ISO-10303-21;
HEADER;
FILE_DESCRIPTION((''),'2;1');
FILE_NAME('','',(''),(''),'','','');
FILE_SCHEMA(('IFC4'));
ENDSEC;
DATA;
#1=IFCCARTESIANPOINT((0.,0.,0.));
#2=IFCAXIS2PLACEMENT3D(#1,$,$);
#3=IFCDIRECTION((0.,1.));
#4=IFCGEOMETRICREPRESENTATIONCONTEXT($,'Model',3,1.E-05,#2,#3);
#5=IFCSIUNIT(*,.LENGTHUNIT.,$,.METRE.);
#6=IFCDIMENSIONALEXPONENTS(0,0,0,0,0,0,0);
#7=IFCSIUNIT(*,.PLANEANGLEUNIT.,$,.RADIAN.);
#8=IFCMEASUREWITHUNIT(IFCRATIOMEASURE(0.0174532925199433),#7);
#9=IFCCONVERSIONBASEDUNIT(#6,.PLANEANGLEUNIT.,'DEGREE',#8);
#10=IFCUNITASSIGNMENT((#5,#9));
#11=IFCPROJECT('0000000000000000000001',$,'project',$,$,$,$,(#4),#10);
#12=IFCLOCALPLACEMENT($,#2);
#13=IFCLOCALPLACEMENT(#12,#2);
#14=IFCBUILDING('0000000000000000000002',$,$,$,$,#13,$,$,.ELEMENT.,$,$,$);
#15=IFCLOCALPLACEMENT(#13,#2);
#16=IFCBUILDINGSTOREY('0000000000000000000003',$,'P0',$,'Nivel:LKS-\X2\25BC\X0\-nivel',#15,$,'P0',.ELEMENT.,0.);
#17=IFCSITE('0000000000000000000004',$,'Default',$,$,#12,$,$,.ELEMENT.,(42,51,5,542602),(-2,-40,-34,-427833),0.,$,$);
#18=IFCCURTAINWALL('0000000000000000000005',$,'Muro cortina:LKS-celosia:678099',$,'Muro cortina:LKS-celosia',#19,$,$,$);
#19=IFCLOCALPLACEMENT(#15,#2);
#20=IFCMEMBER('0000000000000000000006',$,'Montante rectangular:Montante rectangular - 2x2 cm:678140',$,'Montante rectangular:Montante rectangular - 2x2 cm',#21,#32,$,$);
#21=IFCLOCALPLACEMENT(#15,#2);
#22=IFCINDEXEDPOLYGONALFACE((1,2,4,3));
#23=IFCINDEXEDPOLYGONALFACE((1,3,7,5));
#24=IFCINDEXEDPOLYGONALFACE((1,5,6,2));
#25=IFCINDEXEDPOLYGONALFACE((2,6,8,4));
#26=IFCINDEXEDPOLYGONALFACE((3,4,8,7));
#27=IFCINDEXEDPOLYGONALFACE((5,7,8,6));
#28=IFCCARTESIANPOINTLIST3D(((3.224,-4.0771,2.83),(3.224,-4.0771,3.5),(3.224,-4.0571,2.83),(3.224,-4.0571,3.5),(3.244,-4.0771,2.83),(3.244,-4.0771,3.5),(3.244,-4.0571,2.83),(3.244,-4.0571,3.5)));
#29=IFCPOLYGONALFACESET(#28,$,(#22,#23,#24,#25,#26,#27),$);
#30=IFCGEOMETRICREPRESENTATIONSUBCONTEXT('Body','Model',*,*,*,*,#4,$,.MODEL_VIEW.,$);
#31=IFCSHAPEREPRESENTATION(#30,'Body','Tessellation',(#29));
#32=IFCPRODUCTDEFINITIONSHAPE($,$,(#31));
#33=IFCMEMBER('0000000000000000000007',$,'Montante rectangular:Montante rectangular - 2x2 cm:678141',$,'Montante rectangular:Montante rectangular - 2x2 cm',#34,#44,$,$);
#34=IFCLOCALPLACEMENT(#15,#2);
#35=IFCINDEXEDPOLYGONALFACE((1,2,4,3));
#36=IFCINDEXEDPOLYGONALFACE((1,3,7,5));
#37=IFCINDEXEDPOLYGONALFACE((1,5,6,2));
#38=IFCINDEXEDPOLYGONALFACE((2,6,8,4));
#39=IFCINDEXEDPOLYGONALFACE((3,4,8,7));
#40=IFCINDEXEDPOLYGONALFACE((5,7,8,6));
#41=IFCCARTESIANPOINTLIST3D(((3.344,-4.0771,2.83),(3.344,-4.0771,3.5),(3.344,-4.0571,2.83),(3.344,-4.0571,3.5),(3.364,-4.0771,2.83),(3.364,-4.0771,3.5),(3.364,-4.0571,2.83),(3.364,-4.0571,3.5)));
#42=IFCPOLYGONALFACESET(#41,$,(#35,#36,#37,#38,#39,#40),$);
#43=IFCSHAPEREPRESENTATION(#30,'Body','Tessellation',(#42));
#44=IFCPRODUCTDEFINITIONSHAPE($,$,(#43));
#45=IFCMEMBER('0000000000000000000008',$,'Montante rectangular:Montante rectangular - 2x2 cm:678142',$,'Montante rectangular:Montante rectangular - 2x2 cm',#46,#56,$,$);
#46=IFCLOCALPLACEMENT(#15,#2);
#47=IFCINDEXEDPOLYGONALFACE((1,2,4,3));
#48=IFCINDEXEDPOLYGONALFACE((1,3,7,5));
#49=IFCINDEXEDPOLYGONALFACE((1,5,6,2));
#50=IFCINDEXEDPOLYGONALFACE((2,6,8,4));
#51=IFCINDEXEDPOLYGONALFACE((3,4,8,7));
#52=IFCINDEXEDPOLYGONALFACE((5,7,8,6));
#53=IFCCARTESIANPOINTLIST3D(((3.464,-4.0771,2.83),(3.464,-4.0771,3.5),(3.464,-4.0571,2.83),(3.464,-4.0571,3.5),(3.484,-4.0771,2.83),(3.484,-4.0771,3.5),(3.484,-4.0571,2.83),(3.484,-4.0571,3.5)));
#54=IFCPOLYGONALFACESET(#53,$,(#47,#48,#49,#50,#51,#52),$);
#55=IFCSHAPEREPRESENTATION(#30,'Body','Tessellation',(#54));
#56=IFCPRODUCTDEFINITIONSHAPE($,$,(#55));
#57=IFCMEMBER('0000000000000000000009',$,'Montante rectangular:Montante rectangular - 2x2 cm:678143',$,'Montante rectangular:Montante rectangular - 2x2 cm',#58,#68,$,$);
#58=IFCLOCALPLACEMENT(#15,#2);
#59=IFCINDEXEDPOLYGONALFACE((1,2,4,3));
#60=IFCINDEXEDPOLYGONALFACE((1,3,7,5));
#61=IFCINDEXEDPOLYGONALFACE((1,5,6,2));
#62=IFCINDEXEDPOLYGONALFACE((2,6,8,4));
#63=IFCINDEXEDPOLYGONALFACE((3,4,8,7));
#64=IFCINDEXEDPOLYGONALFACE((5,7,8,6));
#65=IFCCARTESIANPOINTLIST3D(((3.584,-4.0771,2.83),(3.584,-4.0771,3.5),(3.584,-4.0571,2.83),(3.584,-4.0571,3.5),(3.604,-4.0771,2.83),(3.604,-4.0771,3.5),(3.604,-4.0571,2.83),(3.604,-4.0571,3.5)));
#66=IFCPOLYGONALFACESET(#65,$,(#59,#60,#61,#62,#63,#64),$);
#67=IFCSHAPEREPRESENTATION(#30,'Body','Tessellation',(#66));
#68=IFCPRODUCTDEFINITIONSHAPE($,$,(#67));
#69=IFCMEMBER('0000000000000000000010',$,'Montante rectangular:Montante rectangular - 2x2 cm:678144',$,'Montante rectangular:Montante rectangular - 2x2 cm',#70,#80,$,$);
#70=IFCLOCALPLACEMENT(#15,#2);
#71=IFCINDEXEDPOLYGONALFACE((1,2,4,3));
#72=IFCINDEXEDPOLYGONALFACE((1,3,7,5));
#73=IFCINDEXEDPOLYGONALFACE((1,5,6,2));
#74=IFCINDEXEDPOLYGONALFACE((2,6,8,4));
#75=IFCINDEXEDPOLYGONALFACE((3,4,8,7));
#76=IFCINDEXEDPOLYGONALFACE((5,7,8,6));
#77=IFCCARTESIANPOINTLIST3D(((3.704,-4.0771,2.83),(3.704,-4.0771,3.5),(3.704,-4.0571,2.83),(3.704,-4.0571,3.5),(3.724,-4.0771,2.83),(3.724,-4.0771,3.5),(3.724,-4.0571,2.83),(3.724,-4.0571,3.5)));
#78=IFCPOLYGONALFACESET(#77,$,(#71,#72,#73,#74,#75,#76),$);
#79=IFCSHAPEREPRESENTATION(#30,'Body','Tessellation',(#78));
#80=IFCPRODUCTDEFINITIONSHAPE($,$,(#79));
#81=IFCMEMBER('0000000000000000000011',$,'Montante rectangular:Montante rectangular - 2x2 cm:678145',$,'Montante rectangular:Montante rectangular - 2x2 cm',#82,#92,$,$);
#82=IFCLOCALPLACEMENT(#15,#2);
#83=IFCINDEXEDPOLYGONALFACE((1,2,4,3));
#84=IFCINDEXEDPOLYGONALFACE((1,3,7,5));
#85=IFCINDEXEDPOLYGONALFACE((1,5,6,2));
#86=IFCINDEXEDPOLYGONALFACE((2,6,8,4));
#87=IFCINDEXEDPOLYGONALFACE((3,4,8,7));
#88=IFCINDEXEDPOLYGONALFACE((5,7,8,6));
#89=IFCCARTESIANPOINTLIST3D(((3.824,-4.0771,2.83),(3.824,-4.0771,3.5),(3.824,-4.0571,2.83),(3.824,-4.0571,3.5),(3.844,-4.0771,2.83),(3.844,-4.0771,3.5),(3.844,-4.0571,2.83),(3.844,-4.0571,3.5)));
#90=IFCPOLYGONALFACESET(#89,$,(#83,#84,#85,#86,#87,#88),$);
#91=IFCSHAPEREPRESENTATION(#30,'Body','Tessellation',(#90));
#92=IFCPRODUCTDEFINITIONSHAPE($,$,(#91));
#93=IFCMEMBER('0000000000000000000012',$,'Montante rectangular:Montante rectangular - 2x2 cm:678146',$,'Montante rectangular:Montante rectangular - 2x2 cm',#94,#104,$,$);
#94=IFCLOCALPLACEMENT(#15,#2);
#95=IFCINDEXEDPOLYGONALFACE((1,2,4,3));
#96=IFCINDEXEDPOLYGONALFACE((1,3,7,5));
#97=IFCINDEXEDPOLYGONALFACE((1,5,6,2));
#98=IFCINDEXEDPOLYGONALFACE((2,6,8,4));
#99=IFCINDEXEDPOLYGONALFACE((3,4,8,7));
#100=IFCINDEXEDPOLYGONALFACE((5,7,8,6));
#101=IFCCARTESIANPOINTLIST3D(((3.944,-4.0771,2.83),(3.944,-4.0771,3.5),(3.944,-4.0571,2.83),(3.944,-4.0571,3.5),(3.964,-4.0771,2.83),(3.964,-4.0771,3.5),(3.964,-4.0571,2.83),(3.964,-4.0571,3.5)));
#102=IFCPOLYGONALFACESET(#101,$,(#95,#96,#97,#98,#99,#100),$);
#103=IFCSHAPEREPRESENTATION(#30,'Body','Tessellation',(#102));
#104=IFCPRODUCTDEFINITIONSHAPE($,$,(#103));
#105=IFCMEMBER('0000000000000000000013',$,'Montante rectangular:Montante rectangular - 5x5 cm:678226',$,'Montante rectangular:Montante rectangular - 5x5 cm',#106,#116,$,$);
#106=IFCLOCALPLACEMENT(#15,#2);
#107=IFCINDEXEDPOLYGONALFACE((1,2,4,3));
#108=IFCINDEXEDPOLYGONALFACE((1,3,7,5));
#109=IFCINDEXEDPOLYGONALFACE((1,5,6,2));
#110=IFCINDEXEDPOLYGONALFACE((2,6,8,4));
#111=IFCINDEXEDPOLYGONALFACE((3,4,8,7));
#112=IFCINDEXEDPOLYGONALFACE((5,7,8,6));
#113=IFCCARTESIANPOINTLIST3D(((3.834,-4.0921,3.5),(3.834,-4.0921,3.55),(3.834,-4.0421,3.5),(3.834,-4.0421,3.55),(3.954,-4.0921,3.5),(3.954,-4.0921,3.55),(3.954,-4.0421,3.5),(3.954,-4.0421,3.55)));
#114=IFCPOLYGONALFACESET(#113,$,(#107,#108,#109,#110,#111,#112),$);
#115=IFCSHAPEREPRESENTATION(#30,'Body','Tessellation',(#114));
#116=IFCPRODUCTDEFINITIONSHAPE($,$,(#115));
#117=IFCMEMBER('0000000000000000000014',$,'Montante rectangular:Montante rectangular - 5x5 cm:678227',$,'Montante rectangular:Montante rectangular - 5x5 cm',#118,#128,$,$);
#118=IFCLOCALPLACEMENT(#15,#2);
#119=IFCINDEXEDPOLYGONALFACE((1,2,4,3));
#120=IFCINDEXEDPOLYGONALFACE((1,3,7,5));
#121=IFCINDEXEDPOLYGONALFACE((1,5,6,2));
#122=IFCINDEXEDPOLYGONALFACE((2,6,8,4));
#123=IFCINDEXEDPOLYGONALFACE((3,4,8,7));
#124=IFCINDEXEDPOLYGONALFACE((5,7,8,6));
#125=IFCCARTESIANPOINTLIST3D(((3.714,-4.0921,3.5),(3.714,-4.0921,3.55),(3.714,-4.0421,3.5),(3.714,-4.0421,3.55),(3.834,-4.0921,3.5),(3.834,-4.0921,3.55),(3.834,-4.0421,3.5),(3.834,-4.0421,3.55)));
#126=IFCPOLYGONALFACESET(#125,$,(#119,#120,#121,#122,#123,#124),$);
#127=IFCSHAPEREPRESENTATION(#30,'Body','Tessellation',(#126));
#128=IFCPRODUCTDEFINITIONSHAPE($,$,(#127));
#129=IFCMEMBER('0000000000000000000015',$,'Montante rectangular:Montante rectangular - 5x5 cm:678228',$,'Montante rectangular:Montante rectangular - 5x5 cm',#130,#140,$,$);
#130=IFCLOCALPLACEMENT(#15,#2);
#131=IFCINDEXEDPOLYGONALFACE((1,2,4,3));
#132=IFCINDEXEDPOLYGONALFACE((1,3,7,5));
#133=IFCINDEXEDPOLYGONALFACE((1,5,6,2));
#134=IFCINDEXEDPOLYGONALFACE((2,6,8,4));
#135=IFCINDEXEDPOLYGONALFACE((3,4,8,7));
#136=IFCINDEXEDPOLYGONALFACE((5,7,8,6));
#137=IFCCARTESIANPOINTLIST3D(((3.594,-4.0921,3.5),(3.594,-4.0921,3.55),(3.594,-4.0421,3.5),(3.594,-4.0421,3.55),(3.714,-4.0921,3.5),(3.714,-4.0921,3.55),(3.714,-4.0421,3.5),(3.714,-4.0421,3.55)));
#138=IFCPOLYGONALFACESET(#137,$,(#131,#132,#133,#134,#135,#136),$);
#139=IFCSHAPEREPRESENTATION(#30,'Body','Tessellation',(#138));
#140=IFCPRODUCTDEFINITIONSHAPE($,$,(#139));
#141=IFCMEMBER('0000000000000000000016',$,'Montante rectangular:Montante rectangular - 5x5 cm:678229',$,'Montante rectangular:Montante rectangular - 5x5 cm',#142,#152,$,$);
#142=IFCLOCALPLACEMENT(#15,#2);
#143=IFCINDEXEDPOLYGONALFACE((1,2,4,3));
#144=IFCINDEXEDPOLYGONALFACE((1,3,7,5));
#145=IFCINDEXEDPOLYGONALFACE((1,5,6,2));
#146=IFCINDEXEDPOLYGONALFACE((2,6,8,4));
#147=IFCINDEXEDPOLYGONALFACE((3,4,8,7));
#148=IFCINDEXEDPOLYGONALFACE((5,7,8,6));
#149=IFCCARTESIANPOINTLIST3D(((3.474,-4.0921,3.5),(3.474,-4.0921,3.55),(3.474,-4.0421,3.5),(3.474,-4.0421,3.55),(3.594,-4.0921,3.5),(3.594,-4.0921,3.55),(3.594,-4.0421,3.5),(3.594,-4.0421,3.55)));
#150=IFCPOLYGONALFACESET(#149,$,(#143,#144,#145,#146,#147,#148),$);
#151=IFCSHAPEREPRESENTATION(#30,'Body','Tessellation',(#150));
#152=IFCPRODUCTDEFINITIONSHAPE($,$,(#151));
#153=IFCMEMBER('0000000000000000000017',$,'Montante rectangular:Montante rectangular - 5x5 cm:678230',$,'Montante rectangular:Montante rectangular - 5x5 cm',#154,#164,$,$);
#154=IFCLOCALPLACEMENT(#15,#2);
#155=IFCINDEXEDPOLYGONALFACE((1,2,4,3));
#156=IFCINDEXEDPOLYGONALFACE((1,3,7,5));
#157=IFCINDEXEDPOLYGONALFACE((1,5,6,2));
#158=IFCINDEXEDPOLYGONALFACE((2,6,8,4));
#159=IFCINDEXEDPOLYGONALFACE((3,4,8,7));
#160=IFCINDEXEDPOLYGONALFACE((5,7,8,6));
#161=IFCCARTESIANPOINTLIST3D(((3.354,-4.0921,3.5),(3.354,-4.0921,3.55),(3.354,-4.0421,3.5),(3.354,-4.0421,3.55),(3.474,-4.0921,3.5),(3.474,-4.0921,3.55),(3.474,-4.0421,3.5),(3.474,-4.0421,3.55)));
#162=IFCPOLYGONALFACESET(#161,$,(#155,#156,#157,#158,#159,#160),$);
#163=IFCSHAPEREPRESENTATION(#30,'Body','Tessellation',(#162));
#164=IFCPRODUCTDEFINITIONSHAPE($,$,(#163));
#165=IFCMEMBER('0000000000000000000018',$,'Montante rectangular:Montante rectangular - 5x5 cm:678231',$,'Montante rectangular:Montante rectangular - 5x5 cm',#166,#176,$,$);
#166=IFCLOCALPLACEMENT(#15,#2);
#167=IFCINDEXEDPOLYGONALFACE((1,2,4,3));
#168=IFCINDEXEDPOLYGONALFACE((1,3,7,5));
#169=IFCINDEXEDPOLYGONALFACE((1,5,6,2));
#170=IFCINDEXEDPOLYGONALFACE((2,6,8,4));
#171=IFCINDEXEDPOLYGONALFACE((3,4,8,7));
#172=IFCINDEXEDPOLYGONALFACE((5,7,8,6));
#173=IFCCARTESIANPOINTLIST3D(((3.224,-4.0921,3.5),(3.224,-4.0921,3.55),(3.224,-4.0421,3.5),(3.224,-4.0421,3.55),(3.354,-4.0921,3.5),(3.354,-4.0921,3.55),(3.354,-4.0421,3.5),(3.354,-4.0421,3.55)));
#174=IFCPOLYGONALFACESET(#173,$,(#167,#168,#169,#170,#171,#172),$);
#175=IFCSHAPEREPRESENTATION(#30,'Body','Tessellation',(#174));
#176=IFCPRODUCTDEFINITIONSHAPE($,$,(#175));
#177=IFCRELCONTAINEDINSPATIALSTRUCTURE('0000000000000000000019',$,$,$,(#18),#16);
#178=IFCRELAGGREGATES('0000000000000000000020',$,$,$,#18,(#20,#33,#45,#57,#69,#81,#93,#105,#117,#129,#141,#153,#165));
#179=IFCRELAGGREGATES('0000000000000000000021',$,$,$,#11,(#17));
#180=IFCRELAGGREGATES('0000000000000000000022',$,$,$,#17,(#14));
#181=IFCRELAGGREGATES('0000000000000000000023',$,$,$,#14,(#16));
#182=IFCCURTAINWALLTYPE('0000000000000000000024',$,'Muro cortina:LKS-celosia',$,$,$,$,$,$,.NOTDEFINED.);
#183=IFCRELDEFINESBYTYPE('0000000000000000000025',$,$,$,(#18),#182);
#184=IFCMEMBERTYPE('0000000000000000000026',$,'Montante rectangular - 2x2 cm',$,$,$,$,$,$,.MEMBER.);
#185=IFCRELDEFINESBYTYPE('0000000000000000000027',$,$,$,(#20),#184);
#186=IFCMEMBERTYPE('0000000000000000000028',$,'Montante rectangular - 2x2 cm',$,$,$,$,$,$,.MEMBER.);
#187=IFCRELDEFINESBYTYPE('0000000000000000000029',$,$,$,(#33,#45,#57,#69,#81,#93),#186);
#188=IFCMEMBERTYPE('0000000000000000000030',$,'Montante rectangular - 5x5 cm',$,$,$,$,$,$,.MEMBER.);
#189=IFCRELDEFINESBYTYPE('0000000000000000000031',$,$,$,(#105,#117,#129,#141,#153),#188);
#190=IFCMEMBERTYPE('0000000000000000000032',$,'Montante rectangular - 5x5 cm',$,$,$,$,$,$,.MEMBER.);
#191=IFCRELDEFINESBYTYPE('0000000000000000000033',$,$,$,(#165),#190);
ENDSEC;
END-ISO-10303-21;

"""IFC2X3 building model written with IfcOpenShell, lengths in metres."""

from ifc_helpers import new_model, entity, si_unit, converted_unit, direction, frame, origin, origin_2d_with_axis, place, context, subcontext, project, spatial, rectangle, extrude, source, transform, mapped, type_object, type_shapes, element, aggregate, save


model = new_model("IFC2X3")

# Units and contexts
model_context = context("Model", 3, precision=1e-05, world=origin(), true_north=direction((0.0, 1.0)))
body_context = subcontext(model_context, "Body", "Model", "MODEL_VIEW")
ifc_project = project(units=[si_unit("LENGTHUNIT", "METRE"), converted_unit("PLANEANGLEUNIT", "DEGREE", entity("IfcRatioMeasure", 0.0174532925199433), si_unit("PLANEANGLEUNIT", "RADIAN"), dimensions=[0, 0, 0, 0, 0, 0, 0])], contexts=[model_context])

# Site, building, storey
site_placement = place(None, origin())
site = spatial("IfcSite", under=ifc_project, at=site_placement, Name="Default", CompositionType="ELEMENT", RefLatitude=(42, 51, 5, 542602), RefLongitude=(-2, -40, -34, -427833), RefElevation=0.0)
building_placement = place(site_placement, origin())
building = spatial("IfcBuilding", under=site, at=building_placement, CompositionType="ELEMENT")
storey_placement = place(building_placement, origin())
storey = spatial("IfcBuildingStorey", under=building, at=storey_placement, Name="P0", ObjectType="Nivel:LKS-▼-nivel", LongName="P0", CompositionType="ELEMENT", Elevation=0.0)

# Curtain wall, members
curtain_wall_type = type_object("IfcCurtainWallType", Name="Muro cortina:LKS-celosia", PredefinedType="NOTDEFINED")
curtain_wall_placement = place(storey_placement, origin())
curtain_wall = element("IfcCurtainWall", 1, at=curtain_wall_placement, inside=storey, type_object=curtain_wall_type, Name="Muro cortina:LKS-celosia:678099", ObjectType="Muro cortina:LKS-celosia")
member_type_1 = type_object("IfcMemberType", Name="Montante rectangular - 2x2 cm", PredefinedType="MEMBER")
shared_shape_1 = source(origin(), body_context, "Body", "SweptSolid", [
    extrude(rectangle(XDim=0.02, YDim=0.02, at=origin_2d_with_axis()), frame((-0.01, -0.1, -0.67), z_axis=(0.0, 0.0, 1.0), x_axis=(0.0, -1.0, 0.0)), (0.0, 0.0, 1.0), 0.67),
])
type_shapes(member_type_1, [shared_shape_1])
member_1_placement = place(storey_placement, frame((3.224, -4.1671, 3.5), z_axis=(0.0, 0.0, 1.0), x_axis=(-1.0, 0.0, 0.0)))
member_1 = element("IfcMember", 2, at=member_1_placement, type_object=member_type_1, Name="Montante rectangular:Montante rectangular - 2x2 cm:678140", ObjectType="Montante rectangular:Montante rectangular - 2x2 cm", context=body_context, shape_type="MappedRepresentation", body=[
    mapped(shared_shape_1, transform((0.0, 0.0, 0.0), scale=1.0)),
])
member_type_2 = type_object("IfcMemberType", Name="Montante rectangular - 2x2 cm", PredefinedType="MEMBER")
shared_shape_2 = source(origin(), body_context, "Body", "SweptSolid", [
    extrude(rectangle(XDim=0.02, YDim=0.02, at=origin_2d_with_axis()), frame((0.0, -0.1, -0.67), z_axis=(0.0, 0.0, 1.0), x_axis=(0.0, -1.0, 0.0)), (0.0, 0.0, 1.0), 0.67),
])
type_shapes(member_type_2, [shared_shape_2])
member_2_placement = place(storey_placement, frame((3.354, -4.1671, 2.83), z_axis=(0.0, 0.0, -1.0), x_axis=(1.0, 0.0, 0.0)))
member_2 = element("IfcMember", 3, at=member_2_placement, type_object=member_type_2, Name="Montante rectangular:Montante rectangular - 2x2 cm:678141", ObjectType="Montante rectangular:Montante rectangular - 2x2 cm", context=body_context, shape_type="MappedRepresentation", body=[
    mapped(shared_shape_2, transform((0.0, 0.0, 0.0), scale=1.0)),
])
member_3_placement = place(storey_placement, frame((3.474, -4.1671, 2.83), z_axis=(0.0, 0.0, -1.0), x_axis=(1.0, 0.0, 0.0)))
member_3 = element("IfcMember", 4, at=member_3_placement, type_object=member_type_2, Name="Montante rectangular:Montante rectangular - 2x2 cm:678142", ObjectType="Montante rectangular:Montante rectangular - 2x2 cm", context=body_context, shape_type="MappedRepresentation", body=[
    mapped(shared_shape_2, transform((0.0, 0.0, 0.0), scale=1.0)),
])
member_4_placement = place(storey_placement, frame((3.594, -4.1671, 2.83), z_axis=(0.0, 0.0, -1.0), x_axis=(1.0, 0.0, 0.0)))
member_4 = element("IfcMember", 5, at=member_4_placement, type_object=member_type_2, Name="Montante rectangular:Montante rectangular - 2x2 cm:678143", ObjectType="Montante rectangular:Montante rectangular - 2x2 cm", context=body_context, shape_type="MappedRepresentation", body=[
    mapped(shared_shape_2, transform((0.0, 0.0, 0.0), scale=1.0)),
])
member_5_placement = place(storey_placement, frame((3.714, -4.1671, 2.83), z_axis=(0.0, 0.0, -1.0), x_axis=(1.0, 0.0, 0.0)))
member_5 = element("IfcMember", 6, at=member_5_placement, type_object=member_type_2, Name="Montante rectangular:Montante rectangular - 2x2 cm:678144", ObjectType="Montante rectangular:Montante rectangular - 2x2 cm", context=body_context, shape_type="MappedRepresentation", body=[
    mapped(shared_shape_2, transform((0.0, 0.0, 0.0), scale=1.0)),
])
member_6_placement = place(storey_placement, frame((3.834, -4.1671, 2.83), z_axis=(0.0, 0.0, -1.0), x_axis=(1.0, 0.0, 0.0)))
member_6 = element("IfcMember", 7, at=member_6_placement, type_object=member_type_2, Name="Montante rectangular:Montante rectangular - 2x2 cm:678145", ObjectType="Montante rectangular:Montante rectangular - 2x2 cm", context=body_context, shape_type="MappedRepresentation", body=[
    mapped(shared_shape_2, transform((0.0, 0.0, 0.0), scale=1.0)),
])
member_7_placement = place(storey_placement, frame((3.954, -4.1671, 2.83), z_axis=(0.0, 0.0, -1.0), x_axis=(1.0, 0.0, 0.0)))
member_7 = element("IfcMember", 8, at=member_7_placement, type_object=member_type_2, Name="Montante rectangular:Montante rectangular - 2x2 cm:678146", ObjectType="Montante rectangular:Montante rectangular - 2x2 cm", context=body_context, shape_type="MappedRepresentation", body=[
    mapped(shared_shape_2, transform((0.0, 0.0, 0.0), scale=1.0)),
])
member_type_3 = type_object("IfcMemberType", Name="Montante rectangular - 5x5 cm", PredefinedType="MEMBER")
shared_shape_3 = source(origin(), body_context, "Body", "SweptSolid", [
    extrude(rectangle(XDim=0.05, YDim=0.05, at=origin_2d_with_axis()), frame((-0.025, -0.1, -0.12), z_axis=(0.0, 0.0, 1.0), x_axis=(0.0, -1.0, 0.0)), (0.0, 0.0, 1.0), 0.12),
])
type_shapes(member_type_3, [shared_shape_3])
member_8_placement = place(storey_placement, frame((3.954, -4.1671, 3.55), z_axis=(1.0, 0.0, 0.0), x_axis=(0.0, 0.0, 1.0)))
member_8 = element("IfcMember", 9, at=member_8_placement, type_object=member_type_3, Name="Montante rectangular:Montante rectangular - 5x5 cm:678226", ObjectType="Montante rectangular:Montante rectangular - 5x5 cm", context=body_context, shape_type="MappedRepresentation", body=[
    mapped(shared_shape_3, transform((0.0, 0.0, 0.0), scale=1.0)),
])
member_9_placement = place(storey_placement, frame((3.834, -4.1671, 3.55), z_axis=(1.0, 0.0, 0.0), x_axis=(0.0, 0.0, 1.0)))
member_9 = element("IfcMember", 10, at=member_9_placement, type_object=member_type_3, Name="Montante rectangular:Montante rectangular - 5x5 cm:678227", ObjectType="Montante rectangular:Montante rectangular - 5x5 cm", context=body_context, shape_type="MappedRepresentation", body=[
    mapped(shared_shape_3, transform((0.0, 0.0, 0.0), scale=1.0)),
])
member_10_placement = place(storey_placement, frame((3.714, -4.1671, 3.55), z_axis=(1.0, 0.0, 0.0), x_axis=(0.0, 0.0, 1.0)))
member_10 = element("IfcMember", 11, at=member_10_placement, type_object=member_type_3, Name="Montante rectangular:Montante rectangular - 5x5 cm:678228", ObjectType="Montante rectangular:Montante rectangular - 5x5 cm", context=body_context, shape_type="MappedRepresentation", body=[
    mapped(shared_shape_3, transform((0.0, 0.0, 0.0), scale=1.0)),
])
member_11_placement = place(storey_placement, frame((3.594, -4.1671, 3.55), z_axis=(1.0, 0.0, 0.0), x_axis=(0.0, 0.0, 1.0)))
member_11 = element("IfcMember", 12, at=member_11_placement, type_object=member_type_3, Name="Montante rectangular:Montante rectangular - 5x5 cm:678229", ObjectType="Montante rectangular:Montante rectangular - 5x5 cm", context=body_context, shape_type="MappedRepresentation", body=[
    mapped(shared_shape_3, transform((0.0, 0.0, 0.0), scale=1.0)),
])
member_12_placement = place(storey_placement, frame((3.474, -4.1671, 3.55), z_axis=(1.0, 0.0, 0.0), x_axis=(0.0, 0.0, 1.0)))
member_12 = element("IfcMember", 13, at=member_12_placement, type_object=member_type_3, Name="Montante rectangular:Montante rectangular - 5x5 cm:678230", ObjectType="Montante rectangular:Montante rectangular - 5x5 cm", context=body_context, shape_type="MappedRepresentation", body=[
    mapped(shared_shape_3, transform((0.0, 0.0, 0.0), scale=1.0)),
])
member_type_4 = type_object("IfcMemberType", Name="Montante rectangular - 5x5 cm", PredefinedType="MEMBER")
shared_shape_4 = source(origin(), body_context, "Body", "SweptSolid", [
    extrude(rectangle(XDim=0.05, YDim=0.05, at=origin_2d_with_axis()), frame((-0.025, -0.1, -0.13), z_axis=(0.0, 0.0, 1.0), x_axis=(0.0, -1.0, 0.0)), (0.0, 0.0, 1.0), 0.13),
])
type_shapes(member_type_4, [shared_shape_4])
member_13_placement = place(storey_placement, frame((3.354, -4.1671, 3.55), z_axis=(1.0, 0.0, 0.0), x_axis=(0.0, 0.0, 1.0)))
member_13 = element("IfcMember", 14, at=member_13_placement, type_object=member_type_4, Name="Montante rectangular:Montante rectangular - 5x5 cm:678231", ObjectType="Montante rectangular:Montante rectangular - 5x5 cm", context=body_context, shape_type="MappedRepresentation", body=[
    mapped(shared_shape_4, transform((0.0, 0.0, 0.0), scale=1.0)),
])
aggregate(curtain_wall, [member_1, member_2, member_3, member_4, member_5, member_6, member_7, member_8, member_9, member_10, member_11, member_12, member_13])

save(model, "model.ifc")
